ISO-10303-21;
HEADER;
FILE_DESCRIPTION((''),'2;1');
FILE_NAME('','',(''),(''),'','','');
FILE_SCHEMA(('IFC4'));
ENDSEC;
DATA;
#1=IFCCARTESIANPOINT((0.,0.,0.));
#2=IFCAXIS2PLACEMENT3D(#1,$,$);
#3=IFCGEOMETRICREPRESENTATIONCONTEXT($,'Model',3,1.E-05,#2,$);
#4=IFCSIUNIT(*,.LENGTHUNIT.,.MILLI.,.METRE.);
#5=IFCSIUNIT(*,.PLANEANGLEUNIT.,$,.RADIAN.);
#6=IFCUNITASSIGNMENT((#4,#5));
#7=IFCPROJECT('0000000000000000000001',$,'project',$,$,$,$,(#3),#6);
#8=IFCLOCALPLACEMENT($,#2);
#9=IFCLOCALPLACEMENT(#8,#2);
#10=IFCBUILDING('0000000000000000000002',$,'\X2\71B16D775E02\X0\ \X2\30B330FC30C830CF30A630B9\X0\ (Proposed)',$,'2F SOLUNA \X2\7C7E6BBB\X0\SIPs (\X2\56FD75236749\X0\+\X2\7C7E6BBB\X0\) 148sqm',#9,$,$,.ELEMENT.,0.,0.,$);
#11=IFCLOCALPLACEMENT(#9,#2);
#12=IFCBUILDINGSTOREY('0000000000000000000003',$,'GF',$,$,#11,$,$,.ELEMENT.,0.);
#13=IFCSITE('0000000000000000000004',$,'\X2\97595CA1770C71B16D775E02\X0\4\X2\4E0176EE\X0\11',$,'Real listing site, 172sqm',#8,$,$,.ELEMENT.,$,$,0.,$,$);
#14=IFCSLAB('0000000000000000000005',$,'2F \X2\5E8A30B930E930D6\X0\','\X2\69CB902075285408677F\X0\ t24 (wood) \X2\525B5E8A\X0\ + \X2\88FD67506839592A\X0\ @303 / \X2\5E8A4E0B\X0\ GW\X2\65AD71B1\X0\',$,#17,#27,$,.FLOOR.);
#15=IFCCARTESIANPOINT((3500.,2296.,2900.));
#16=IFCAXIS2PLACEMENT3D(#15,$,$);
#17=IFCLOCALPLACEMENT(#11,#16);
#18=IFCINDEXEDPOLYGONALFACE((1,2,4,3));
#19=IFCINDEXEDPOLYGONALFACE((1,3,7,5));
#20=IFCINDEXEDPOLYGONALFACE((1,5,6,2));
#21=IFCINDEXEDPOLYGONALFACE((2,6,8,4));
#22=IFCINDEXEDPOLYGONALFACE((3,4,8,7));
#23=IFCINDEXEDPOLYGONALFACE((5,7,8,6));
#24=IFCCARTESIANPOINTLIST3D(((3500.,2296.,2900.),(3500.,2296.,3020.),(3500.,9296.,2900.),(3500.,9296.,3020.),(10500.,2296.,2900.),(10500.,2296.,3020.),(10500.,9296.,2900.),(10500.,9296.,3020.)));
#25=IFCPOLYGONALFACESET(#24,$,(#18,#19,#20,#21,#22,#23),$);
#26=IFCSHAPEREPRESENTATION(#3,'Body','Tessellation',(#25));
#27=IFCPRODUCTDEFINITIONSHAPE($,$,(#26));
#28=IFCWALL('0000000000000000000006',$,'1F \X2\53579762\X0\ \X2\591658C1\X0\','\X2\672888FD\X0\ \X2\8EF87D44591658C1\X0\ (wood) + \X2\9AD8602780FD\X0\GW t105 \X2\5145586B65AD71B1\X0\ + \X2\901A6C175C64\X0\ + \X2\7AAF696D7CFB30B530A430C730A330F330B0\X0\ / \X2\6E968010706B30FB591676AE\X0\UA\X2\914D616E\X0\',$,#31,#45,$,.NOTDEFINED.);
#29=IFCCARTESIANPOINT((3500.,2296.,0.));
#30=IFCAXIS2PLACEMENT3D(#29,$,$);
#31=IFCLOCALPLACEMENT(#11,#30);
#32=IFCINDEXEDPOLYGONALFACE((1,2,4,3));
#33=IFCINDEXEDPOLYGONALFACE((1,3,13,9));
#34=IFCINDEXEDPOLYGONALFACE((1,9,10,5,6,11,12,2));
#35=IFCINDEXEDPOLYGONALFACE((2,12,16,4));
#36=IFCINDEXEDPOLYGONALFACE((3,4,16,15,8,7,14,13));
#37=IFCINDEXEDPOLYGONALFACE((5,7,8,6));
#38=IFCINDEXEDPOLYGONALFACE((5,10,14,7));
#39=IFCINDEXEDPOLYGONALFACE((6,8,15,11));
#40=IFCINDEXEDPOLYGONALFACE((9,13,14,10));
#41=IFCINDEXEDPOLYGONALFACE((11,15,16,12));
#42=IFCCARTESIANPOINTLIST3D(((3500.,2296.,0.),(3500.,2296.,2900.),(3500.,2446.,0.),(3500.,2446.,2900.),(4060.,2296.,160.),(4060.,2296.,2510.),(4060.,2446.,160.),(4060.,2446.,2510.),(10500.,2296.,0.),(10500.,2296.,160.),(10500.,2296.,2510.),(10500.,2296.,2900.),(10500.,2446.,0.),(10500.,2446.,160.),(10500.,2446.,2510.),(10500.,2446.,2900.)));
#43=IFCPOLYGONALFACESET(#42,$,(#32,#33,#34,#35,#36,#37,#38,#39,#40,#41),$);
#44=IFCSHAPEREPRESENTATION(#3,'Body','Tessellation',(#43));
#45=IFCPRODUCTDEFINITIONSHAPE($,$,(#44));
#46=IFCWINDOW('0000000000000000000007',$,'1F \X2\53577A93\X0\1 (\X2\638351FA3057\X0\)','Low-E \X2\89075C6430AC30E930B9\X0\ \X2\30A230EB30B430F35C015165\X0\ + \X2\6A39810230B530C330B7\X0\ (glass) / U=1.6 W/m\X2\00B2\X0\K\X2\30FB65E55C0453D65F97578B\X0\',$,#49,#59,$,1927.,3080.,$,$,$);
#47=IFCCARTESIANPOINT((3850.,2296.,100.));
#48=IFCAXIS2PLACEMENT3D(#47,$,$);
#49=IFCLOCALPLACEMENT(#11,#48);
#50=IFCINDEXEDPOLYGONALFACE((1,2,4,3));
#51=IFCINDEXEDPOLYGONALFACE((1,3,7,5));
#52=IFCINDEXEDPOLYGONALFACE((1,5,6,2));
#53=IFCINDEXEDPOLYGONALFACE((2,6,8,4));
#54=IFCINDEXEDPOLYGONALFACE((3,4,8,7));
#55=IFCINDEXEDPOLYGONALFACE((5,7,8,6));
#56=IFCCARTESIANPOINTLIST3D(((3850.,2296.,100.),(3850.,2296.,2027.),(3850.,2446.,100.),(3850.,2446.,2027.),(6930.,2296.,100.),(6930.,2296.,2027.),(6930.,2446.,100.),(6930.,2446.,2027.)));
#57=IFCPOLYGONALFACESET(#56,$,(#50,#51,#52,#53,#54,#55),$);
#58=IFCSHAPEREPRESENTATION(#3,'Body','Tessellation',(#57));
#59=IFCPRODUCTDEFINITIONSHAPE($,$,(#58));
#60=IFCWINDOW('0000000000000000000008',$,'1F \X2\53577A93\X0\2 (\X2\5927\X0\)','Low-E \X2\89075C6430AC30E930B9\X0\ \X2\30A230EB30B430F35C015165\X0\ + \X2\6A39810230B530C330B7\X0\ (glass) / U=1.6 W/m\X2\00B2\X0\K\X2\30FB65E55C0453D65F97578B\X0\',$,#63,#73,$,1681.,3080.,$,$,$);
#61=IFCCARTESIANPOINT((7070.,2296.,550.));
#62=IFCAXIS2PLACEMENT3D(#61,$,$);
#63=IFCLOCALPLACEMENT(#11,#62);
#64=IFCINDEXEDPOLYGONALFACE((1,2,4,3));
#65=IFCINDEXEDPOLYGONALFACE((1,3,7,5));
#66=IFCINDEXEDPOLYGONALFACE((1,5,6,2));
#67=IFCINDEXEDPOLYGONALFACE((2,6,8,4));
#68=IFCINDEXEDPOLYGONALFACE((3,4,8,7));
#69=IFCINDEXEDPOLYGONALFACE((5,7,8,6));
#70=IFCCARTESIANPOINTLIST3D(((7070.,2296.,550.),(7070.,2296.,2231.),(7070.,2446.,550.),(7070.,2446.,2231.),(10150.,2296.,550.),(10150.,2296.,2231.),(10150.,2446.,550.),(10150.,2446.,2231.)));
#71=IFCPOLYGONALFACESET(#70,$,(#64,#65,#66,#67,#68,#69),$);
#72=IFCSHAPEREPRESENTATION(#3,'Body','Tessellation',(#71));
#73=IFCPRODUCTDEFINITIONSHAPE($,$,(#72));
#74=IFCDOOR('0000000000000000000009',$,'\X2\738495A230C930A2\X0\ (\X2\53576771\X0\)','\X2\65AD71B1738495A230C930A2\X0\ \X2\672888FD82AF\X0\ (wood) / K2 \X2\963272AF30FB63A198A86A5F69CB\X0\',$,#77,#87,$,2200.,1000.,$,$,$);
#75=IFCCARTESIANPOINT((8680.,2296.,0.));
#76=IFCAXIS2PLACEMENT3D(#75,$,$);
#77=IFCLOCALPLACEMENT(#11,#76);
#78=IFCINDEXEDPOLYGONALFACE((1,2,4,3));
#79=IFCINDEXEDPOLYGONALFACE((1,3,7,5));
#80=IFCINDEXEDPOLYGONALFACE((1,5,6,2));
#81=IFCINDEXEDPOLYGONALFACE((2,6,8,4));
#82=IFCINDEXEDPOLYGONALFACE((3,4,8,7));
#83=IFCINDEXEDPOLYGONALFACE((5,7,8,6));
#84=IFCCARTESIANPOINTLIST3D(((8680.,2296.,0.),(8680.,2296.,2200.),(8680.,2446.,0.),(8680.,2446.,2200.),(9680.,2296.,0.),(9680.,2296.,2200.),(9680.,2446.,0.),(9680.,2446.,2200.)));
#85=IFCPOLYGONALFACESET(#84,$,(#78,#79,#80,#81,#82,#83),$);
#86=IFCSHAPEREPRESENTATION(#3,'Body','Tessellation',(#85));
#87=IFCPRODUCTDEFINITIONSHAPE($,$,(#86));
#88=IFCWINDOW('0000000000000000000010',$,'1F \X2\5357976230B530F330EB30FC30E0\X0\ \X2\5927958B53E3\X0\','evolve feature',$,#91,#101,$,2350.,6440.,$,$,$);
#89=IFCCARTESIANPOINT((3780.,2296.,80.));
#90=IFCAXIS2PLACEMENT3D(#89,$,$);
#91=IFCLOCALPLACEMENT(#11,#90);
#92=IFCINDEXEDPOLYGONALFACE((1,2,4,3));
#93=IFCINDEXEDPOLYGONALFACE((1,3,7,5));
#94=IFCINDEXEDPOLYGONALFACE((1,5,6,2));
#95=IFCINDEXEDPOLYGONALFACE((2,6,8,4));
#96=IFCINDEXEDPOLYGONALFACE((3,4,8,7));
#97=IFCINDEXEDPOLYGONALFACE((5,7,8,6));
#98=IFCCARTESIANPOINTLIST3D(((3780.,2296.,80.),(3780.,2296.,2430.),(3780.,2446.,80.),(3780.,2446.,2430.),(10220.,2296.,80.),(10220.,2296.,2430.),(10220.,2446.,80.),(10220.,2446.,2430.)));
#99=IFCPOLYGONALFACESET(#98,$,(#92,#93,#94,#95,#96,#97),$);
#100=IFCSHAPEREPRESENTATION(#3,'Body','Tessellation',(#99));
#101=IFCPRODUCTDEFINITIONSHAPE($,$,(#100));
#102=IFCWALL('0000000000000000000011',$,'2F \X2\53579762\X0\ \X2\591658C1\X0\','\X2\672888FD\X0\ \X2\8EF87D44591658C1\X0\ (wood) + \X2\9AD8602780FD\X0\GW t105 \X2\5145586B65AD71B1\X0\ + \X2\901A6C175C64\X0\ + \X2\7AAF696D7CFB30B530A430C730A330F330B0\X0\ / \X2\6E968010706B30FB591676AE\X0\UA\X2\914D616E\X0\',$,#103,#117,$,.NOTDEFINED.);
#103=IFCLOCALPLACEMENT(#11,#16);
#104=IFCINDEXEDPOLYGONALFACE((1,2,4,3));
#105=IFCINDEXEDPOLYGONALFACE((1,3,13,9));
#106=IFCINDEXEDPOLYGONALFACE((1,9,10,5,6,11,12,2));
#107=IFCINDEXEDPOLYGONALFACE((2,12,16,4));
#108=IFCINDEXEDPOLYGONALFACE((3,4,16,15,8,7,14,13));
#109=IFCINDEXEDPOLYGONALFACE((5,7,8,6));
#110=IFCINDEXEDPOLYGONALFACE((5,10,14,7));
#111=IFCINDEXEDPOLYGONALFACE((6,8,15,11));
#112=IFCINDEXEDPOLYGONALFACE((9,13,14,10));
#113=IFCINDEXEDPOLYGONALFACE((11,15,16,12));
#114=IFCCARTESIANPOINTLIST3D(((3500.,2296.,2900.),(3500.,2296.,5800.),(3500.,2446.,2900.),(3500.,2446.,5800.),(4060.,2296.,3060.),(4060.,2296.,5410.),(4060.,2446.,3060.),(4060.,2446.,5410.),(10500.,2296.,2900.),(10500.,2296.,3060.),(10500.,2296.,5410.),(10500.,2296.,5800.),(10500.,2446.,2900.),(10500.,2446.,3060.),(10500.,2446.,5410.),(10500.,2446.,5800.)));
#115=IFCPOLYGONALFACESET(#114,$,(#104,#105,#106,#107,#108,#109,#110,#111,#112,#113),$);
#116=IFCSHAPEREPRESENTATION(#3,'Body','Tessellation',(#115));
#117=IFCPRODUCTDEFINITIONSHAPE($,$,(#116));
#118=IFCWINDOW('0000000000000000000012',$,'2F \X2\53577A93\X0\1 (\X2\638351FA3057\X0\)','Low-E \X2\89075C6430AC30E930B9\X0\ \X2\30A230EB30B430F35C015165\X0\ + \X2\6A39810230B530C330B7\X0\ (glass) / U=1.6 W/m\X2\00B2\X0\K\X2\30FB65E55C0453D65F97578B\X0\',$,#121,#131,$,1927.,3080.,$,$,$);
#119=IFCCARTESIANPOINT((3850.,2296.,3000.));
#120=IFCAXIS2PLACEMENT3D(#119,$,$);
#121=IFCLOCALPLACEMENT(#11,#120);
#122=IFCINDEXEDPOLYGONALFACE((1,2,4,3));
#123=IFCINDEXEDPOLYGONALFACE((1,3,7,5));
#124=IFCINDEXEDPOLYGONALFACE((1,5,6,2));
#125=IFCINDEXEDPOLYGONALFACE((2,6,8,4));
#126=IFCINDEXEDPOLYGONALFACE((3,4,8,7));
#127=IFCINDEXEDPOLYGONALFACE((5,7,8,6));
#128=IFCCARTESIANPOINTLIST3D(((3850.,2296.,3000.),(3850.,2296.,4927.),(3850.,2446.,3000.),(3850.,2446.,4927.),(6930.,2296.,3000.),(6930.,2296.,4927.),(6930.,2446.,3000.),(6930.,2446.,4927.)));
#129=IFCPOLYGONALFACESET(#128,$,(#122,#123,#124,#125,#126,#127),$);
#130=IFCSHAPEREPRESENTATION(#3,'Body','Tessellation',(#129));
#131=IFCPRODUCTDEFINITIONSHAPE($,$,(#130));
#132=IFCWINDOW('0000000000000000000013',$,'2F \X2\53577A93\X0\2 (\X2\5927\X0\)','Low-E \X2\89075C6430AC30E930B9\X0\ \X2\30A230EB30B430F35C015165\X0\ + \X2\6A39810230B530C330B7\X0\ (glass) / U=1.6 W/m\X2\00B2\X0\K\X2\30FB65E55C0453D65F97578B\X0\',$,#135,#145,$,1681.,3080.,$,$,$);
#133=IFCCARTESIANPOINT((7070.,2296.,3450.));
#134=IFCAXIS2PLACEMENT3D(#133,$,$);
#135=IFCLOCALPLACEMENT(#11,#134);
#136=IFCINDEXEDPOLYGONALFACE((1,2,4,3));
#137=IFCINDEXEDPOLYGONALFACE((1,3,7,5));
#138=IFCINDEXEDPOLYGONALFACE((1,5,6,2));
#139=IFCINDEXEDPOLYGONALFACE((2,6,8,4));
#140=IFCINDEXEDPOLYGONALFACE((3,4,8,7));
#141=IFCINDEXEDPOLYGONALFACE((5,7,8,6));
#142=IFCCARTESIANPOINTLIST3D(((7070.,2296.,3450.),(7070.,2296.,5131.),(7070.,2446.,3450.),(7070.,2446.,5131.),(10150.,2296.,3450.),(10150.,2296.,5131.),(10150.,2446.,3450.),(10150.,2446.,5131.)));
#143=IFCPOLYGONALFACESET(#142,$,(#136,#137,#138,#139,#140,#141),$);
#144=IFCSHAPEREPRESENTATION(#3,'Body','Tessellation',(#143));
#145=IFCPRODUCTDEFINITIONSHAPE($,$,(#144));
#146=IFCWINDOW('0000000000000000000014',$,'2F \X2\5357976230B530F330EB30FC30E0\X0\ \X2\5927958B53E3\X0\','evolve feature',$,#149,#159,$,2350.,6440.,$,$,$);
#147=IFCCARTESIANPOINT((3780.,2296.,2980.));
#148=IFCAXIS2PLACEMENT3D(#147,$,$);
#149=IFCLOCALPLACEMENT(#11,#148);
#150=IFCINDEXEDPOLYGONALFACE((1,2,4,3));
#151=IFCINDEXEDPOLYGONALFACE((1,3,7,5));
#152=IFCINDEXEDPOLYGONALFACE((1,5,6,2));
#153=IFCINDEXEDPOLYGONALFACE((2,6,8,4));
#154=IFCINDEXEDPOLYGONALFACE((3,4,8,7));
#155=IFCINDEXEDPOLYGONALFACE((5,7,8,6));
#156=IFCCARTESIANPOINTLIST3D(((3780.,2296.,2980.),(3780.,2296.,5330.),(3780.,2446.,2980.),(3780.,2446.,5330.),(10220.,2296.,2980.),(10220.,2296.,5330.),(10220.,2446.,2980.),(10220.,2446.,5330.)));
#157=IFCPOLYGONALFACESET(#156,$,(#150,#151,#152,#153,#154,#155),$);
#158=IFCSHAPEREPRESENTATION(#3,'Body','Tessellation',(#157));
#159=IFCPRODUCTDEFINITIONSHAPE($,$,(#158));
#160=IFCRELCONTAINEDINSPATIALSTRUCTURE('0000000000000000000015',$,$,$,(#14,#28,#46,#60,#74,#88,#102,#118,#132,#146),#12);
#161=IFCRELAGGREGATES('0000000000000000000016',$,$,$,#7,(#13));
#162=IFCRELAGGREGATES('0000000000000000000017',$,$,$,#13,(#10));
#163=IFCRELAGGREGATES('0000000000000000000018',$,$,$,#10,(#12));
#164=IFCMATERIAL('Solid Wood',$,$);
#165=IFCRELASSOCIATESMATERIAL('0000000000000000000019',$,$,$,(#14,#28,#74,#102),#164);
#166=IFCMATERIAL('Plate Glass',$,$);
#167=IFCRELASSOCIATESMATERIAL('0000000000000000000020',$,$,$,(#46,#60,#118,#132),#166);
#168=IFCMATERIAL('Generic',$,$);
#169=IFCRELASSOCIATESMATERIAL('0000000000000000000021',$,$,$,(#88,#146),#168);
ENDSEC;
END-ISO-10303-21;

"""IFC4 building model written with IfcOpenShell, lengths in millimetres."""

from ifc_helpers import new_model, si_unit, frame, frame_2d, origin, place, context, project, spatial, rectangle, extrude, material, element, fill, save


model = new_model("IFC4")

# Units and contexts
model_context = context("Model", 3, precision=1e-05, world=origin())
ifc_project = project(units=[si_unit("LENGTHUNIT", "METRE", prefix="MILLI"), si_unit("PLANEANGLEUNIT", "RADIAN")], contexts=[model_context])

# Site, building, storey
site_placement = place(None, origin())
site = spatial("IfcSite", under=ifc_project, at=site_placement, Name="静岡県熱海市4丁目11", ObjectType="Real listing site, 172sqm", CompositionType="ELEMENT", RefElevation=0.0)
building_placement = place(site_placement, origin())
building = spatial("IfcBuilding", under=site, at=building_placement, Name="熱海市 コートハウス (Proposed)", ObjectType="2F SOLUNA 籾殻SIPs (国産杉+籾殻) 148sqm", CompositionType="ELEMENT", ElevationOfRefHeight=0.0, ElevationOfTerrain=0.0)
storey_placement = place(building_placement, origin())
storey = spatial("IfcBuildingStorey", under=building, at=storey_placement, Name="GF", CompositionType="ELEMENT", Elevation=0.0)

# Slab
ifc_material_1 = material(Name="Solid Wood")
slab_1_placement = place(storey_placement, frame((3500.0, 2296.0, 2900.0)))
element("IfcSlab", 1, at=slab_1_placement, inside=storey, material=ifc_material_1, Name="2F 床スラブ", Description="構造用合板 t24 (wood) 剛床 + 製材根太 @303 / 床下 GW断熱", PredefinedType="FLOOR", context=model_context, shape_type="SweptSolid", body=[
    extrude(rectangle(XDim=7000.0, YDim=7000.0, at=frame_2d((3500.0, 3500.0))), frame((3500.0, 2296.0, 2900.0)), (0.0, 0.0, 1.0), 120.0),
])
ifc_material_2 = material(Name="Generic")

# Wall, openings, windows, door
wall_1_placement = place(storey_placement, frame((3500.0, 2296.0, 0.0)))
wall_1 = element("IfcWall", 2, at=wall_1_placement, inside=storey, material=ifc_material_1, Name="1F 南面 外壁", Description="木製 軸組外壁 (wood) + 高性能GW t105 充填断熱 + 通気層 + 窯業系サイディング / 準耐火・外皮UA配慮", PredefinedType="NOTDEFINED", context=model_context, shape_type="SweptSolid", body=[
    extrude(rectangle(XDim=7000.0, YDim=150.0, at=frame_2d((3500.0, 75.0))), frame((3500.0, 2296.0, 0.0)), (0.0, 0.0, 1.0), 2900.0),
])
opening_1_placement = place(storey_placement, frame((3850.0, 2296.0, 100.0)))
opening_1 = element("IfcOpeningElement", 3, at=opening_1_placement, cuts=wall_1, PredefinedType="NOTDEFINED", context=model_context, shape_type="SweptSolid", body=[
    extrude(rectangle(XDim=3080.0, YDim=150.0, at=frame_2d((1540.0, 75.0))), frame((3850.0, 2296.0, 100.0)), (0.0, 0.0, 1.0), 1927.0),
])
opening_2_placement = place(storey_placement, frame((7070.0, 2296.0, 550.0)))
opening_2 = element("IfcOpeningElement", 4, at=opening_2_placement, cuts=wall_1, PredefinedType="NOTDEFINED", context=model_context, shape_type="SweptSolid", body=[
    extrude(rectangle(XDim=3080.0, YDim=150.0, at=frame_2d((1540.0, 75.0))), frame((7070.0, 2296.0, 550.0)), (0.0, 0.0, 1.0), 1681.0),
])
opening_3_placement = place(storey_placement, frame((8680.0, 2296.0, 0.0)))
opening_3 = element("IfcOpeningElement", 5, at=opening_3_placement, cuts=wall_1, PredefinedType="NOTDEFINED", context=model_context, shape_type="SweptSolid", body=[
    extrude(rectangle(XDim=1000.0, YDim=150.0, at=frame_2d((500.0, 75.0))), frame((8680.0, 2296.0, 0.0)), (0.0, 0.0, 1.0), 2200.0),
])
opening_4_placement = place(storey_placement, frame((3780.0, 2296.0, 80.0)))
opening_4 = element("IfcOpeningElement", 6, at=opening_4_placement, cuts=wall_1, PredefinedType="NOTDEFINED", context=model_context, shape_type="SweptSolid", body=[
    extrude(rectangle(XDim=6440.0, YDim=150.0, at=frame_2d((3220.0, 75.0))), frame((3780.0, 2296.0, 80.0)), (0.0, 0.0, 1.0), 2350.0),
])
ifc_material_3 = material(Name="Plate Glass")
window_1_placement = place(storey_placement, frame((3850.0, 2296.0, 100.0)))
window_1 = element("IfcWindow", 7, at=window_1_placement, inside=storey, material=ifc_material_3, Name="1F 南窓1 (掃出し)", Description="Low-E 複層ガラス アルゴン封入 + 樹脂サッシ (glass) / U=1.6 W/m²K・日射取得型", OverallHeight=1927.0, OverallWidth=3080.0, context=model_context, shape_type="SweptSolid", body=[
    extrude(rectangle(XDim=3080.0, YDim=150.0, at=frame_2d((1540.0, 75.0))), frame((3850.0, 2296.0, 100.0)), (0.0, 0.0, 1.0), 1927.0),
])
fill(opening_1, window_1)
window_2_placement = place(storey_placement, frame((7070.0, 2296.0, 550.0)))
window_2 = element("IfcWindow", 8, at=window_2_placement, inside=storey, material=ifc_material_3, Name="1F 南窓2 (大)", Description="Low-E 複層ガラス アルゴン封入 + 樹脂サッシ (glass) / U=1.6 W/m²K・日射取得型", OverallHeight=1681.0, OverallWidth=3080.0, context=model_context, shape_type="SweptSolid", body=[
    extrude(rectangle(XDim=3080.0, YDim=150.0, at=frame_2d((1540.0, 75.0))), frame((7070.0, 2296.0, 550.0)), (0.0, 0.0, 1.0), 1681.0),
])
fill(opening_2, window_2)
door_placement = place(storey_placement, frame((8680.0, 2296.0, 0.0)))
door = element("IfcDoor", 9, at=door_placement, inside=storey, material=ifc_material_1, Name="玄関ドア (南東)", Description="断熱玄関ドア 木製芯 (wood) / K2 防犯・採風機構", OverallHeight=2200.0, OverallWidth=1000.0, context=model_context, shape_type="SweptSolid", body=[
    extrude(rectangle(XDim=1000.0, YDim=150.0, at=frame_2d((500.0, 75.0))), frame((8680.0, 2296.0, 0.0)), (0.0, 0.0, 1.0), 2200.0),
])
fill(opening_3, door)
window_3_placement = place(storey_placement, frame((3780.0, 2296.0, 80.0)))
window_3 = element("IfcWindow", 10, at=window_3_placement, inside=storey, material=ifc_material_2, Name="1F 南面サンルーム 大開口", Description="evolve feature", OverallHeight=2350.0, OverallWidth=6440.0, context=model_context, shape_type="SweptSolid", body=[
    extrude(rectangle(XDim=6440.0, YDim=150.0, at=frame_2d((3220.0, 75.0))), frame((3780.0, 2296.0, 80.0)), (0.0, 0.0, 1.0), 2350.0),
])
fill(opening_4, window_3)

# Wall, openings, windows
wall_2_placement = place(storey_placement, frame((3500.0, 2296.0, 2900.0)))
wall_2 = element("IfcWall", 11, at=wall_2_placement, inside=storey, material=ifc_material_1, Name="2F 南面 外壁", Description="木製 軸組外壁 (wood) + 高性能GW t105 充填断熱 + 通気層 + 窯業系サイディング / 準耐火・外皮UA配慮", PredefinedType="NOTDEFINED", context=model_context, shape_type="SweptSolid", body=[
    extrude(rectangle(XDim=7000.0, YDim=150.0, at=frame_2d((3500.0, 75.0))), frame((3500.0, 2296.0, 2900.0)), (0.0, 0.0, 1.0), 2900.0),
])
opening_5_placement = place(storey_placement, frame((3850.0, 2296.0, 3000.0)))
opening_5 = element("IfcOpeningElement", 12, at=opening_5_placement, cuts=wall_2, PredefinedType="NOTDEFINED", context=model_context, shape_type="SweptSolid", body=[
    extrude(rectangle(XDim=3080.0, YDim=150.0, at=frame_2d((1540.0, 75.0))), frame((3850.0, 2296.0, 3000.0)), (0.0, 0.0, 1.0), 1927.0),
])
opening_6_placement = place(storey_placement, frame((7070.0, 2296.0, 3450.0)))
opening_6 = element("IfcOpeningElement", 13, at=opening_6_placement, cuts=wall_2, PredefinedType="NOTDEFINED", context=model_context, shape_type="SweptSolid", body=[
    extrude(rectangle(XDim=3080.0, YDim=150.0, at=frame_2d((1540.0, 75.0))), frame((7070.0, 2296.0, 3450.0)), (0.0, 0.0, 1.0), 1681.0),
])
opening_7_placement = place(storey_placement, frame((3780.0, 2296.0, 2980.0)))
opening_7 = element("IfcOpeningElement", 14, at=opening_7_placement, cuts=wall_2, PredefinedType="NOTDEFINED", context=model_context, shape_type="SweptSolid", body=[
    extrude(rectangle(XDim=6440.0, YDim=150.0, at=frame_2d((3220.0, 75.0))), frame((3780.0, 2296.0, 2980.0)), (0.0, 0.0, 1.0), 2350.0),
])
window_4_placement = place(storey_placement, frame((3850.0, 2296.0, 3000.0)))
window_4 = element("IfcWindow", 15, at=window_4_placement, inside=storey, material=ifc_material_3, Name="2F 南窓1 (掃出し)", Description="Low-E 複層ガラス アルゴン封入 + 樹脂サッシ (glass) / U=1.6 W/m²K・日射取得型", OverallHeight=1927.0, OverallWidth=3080.0, context=model_context, shape_type="SweptSolid", body=[
    extrude(rectangle(XDim=3080.0, YDim=150.0, at=frame_2d((1540.0, 75.0))), frame((3850.0, 2296.0, 3000.0)), (0.0, 0.0, 1.0), 1927.0),
])
fill(opening_5, window_4)
window_5_placement = place(storey_placement, frame((7070.0, 2296.0, 3450.0)))
window_5 = element("IfcWindow", 16, at=window_5_placement, inside=storey, material=ifc_material_3, Name="2F 南窓2 (大)", Description="Low-E 複層ガラス アルゴン封入 + 樹脂サッシ (glass) / U=1.6 W/m²K・日射取得型", OverallHeight=1681.0, OverallWidth=3080.0, context=model_context, shape_type="SweptSolid", body=[
    extrude(rectangle(XDim=3080.0, YDim=150.0, at=frame_2d((1540.0, 75.0))), frame((7070.0, 2296.0, 3450.0)), (0.0, 0.0, 1.0), 1681.0),
])
fill(opening_6, window_5)
window_6_placement = place(storey_placement, frame((3780.0, 2296.0, 2980.0)))
window_6 = element("IfcWindow", 17, at=window_6_placement, inside=storey, material=ifc_material_2, Name="2F 南面サンルーム 大開口", Description="evolve feature", OverallHeight=2350.0, OverallWidth=6440.0, context=model_context, shape_type="SweptSolid", body=[
    extrude(rectangle(XDim=6440.0, YDim=150.0, at=frame_2d((3220.0, 75.0))), frame((3780.0, 2296.0, 2980.0)), (0.0, 0.0, 1.0), 2350.0),
])
fill(opening_7, window_6)

save(model, "model.ifc")
